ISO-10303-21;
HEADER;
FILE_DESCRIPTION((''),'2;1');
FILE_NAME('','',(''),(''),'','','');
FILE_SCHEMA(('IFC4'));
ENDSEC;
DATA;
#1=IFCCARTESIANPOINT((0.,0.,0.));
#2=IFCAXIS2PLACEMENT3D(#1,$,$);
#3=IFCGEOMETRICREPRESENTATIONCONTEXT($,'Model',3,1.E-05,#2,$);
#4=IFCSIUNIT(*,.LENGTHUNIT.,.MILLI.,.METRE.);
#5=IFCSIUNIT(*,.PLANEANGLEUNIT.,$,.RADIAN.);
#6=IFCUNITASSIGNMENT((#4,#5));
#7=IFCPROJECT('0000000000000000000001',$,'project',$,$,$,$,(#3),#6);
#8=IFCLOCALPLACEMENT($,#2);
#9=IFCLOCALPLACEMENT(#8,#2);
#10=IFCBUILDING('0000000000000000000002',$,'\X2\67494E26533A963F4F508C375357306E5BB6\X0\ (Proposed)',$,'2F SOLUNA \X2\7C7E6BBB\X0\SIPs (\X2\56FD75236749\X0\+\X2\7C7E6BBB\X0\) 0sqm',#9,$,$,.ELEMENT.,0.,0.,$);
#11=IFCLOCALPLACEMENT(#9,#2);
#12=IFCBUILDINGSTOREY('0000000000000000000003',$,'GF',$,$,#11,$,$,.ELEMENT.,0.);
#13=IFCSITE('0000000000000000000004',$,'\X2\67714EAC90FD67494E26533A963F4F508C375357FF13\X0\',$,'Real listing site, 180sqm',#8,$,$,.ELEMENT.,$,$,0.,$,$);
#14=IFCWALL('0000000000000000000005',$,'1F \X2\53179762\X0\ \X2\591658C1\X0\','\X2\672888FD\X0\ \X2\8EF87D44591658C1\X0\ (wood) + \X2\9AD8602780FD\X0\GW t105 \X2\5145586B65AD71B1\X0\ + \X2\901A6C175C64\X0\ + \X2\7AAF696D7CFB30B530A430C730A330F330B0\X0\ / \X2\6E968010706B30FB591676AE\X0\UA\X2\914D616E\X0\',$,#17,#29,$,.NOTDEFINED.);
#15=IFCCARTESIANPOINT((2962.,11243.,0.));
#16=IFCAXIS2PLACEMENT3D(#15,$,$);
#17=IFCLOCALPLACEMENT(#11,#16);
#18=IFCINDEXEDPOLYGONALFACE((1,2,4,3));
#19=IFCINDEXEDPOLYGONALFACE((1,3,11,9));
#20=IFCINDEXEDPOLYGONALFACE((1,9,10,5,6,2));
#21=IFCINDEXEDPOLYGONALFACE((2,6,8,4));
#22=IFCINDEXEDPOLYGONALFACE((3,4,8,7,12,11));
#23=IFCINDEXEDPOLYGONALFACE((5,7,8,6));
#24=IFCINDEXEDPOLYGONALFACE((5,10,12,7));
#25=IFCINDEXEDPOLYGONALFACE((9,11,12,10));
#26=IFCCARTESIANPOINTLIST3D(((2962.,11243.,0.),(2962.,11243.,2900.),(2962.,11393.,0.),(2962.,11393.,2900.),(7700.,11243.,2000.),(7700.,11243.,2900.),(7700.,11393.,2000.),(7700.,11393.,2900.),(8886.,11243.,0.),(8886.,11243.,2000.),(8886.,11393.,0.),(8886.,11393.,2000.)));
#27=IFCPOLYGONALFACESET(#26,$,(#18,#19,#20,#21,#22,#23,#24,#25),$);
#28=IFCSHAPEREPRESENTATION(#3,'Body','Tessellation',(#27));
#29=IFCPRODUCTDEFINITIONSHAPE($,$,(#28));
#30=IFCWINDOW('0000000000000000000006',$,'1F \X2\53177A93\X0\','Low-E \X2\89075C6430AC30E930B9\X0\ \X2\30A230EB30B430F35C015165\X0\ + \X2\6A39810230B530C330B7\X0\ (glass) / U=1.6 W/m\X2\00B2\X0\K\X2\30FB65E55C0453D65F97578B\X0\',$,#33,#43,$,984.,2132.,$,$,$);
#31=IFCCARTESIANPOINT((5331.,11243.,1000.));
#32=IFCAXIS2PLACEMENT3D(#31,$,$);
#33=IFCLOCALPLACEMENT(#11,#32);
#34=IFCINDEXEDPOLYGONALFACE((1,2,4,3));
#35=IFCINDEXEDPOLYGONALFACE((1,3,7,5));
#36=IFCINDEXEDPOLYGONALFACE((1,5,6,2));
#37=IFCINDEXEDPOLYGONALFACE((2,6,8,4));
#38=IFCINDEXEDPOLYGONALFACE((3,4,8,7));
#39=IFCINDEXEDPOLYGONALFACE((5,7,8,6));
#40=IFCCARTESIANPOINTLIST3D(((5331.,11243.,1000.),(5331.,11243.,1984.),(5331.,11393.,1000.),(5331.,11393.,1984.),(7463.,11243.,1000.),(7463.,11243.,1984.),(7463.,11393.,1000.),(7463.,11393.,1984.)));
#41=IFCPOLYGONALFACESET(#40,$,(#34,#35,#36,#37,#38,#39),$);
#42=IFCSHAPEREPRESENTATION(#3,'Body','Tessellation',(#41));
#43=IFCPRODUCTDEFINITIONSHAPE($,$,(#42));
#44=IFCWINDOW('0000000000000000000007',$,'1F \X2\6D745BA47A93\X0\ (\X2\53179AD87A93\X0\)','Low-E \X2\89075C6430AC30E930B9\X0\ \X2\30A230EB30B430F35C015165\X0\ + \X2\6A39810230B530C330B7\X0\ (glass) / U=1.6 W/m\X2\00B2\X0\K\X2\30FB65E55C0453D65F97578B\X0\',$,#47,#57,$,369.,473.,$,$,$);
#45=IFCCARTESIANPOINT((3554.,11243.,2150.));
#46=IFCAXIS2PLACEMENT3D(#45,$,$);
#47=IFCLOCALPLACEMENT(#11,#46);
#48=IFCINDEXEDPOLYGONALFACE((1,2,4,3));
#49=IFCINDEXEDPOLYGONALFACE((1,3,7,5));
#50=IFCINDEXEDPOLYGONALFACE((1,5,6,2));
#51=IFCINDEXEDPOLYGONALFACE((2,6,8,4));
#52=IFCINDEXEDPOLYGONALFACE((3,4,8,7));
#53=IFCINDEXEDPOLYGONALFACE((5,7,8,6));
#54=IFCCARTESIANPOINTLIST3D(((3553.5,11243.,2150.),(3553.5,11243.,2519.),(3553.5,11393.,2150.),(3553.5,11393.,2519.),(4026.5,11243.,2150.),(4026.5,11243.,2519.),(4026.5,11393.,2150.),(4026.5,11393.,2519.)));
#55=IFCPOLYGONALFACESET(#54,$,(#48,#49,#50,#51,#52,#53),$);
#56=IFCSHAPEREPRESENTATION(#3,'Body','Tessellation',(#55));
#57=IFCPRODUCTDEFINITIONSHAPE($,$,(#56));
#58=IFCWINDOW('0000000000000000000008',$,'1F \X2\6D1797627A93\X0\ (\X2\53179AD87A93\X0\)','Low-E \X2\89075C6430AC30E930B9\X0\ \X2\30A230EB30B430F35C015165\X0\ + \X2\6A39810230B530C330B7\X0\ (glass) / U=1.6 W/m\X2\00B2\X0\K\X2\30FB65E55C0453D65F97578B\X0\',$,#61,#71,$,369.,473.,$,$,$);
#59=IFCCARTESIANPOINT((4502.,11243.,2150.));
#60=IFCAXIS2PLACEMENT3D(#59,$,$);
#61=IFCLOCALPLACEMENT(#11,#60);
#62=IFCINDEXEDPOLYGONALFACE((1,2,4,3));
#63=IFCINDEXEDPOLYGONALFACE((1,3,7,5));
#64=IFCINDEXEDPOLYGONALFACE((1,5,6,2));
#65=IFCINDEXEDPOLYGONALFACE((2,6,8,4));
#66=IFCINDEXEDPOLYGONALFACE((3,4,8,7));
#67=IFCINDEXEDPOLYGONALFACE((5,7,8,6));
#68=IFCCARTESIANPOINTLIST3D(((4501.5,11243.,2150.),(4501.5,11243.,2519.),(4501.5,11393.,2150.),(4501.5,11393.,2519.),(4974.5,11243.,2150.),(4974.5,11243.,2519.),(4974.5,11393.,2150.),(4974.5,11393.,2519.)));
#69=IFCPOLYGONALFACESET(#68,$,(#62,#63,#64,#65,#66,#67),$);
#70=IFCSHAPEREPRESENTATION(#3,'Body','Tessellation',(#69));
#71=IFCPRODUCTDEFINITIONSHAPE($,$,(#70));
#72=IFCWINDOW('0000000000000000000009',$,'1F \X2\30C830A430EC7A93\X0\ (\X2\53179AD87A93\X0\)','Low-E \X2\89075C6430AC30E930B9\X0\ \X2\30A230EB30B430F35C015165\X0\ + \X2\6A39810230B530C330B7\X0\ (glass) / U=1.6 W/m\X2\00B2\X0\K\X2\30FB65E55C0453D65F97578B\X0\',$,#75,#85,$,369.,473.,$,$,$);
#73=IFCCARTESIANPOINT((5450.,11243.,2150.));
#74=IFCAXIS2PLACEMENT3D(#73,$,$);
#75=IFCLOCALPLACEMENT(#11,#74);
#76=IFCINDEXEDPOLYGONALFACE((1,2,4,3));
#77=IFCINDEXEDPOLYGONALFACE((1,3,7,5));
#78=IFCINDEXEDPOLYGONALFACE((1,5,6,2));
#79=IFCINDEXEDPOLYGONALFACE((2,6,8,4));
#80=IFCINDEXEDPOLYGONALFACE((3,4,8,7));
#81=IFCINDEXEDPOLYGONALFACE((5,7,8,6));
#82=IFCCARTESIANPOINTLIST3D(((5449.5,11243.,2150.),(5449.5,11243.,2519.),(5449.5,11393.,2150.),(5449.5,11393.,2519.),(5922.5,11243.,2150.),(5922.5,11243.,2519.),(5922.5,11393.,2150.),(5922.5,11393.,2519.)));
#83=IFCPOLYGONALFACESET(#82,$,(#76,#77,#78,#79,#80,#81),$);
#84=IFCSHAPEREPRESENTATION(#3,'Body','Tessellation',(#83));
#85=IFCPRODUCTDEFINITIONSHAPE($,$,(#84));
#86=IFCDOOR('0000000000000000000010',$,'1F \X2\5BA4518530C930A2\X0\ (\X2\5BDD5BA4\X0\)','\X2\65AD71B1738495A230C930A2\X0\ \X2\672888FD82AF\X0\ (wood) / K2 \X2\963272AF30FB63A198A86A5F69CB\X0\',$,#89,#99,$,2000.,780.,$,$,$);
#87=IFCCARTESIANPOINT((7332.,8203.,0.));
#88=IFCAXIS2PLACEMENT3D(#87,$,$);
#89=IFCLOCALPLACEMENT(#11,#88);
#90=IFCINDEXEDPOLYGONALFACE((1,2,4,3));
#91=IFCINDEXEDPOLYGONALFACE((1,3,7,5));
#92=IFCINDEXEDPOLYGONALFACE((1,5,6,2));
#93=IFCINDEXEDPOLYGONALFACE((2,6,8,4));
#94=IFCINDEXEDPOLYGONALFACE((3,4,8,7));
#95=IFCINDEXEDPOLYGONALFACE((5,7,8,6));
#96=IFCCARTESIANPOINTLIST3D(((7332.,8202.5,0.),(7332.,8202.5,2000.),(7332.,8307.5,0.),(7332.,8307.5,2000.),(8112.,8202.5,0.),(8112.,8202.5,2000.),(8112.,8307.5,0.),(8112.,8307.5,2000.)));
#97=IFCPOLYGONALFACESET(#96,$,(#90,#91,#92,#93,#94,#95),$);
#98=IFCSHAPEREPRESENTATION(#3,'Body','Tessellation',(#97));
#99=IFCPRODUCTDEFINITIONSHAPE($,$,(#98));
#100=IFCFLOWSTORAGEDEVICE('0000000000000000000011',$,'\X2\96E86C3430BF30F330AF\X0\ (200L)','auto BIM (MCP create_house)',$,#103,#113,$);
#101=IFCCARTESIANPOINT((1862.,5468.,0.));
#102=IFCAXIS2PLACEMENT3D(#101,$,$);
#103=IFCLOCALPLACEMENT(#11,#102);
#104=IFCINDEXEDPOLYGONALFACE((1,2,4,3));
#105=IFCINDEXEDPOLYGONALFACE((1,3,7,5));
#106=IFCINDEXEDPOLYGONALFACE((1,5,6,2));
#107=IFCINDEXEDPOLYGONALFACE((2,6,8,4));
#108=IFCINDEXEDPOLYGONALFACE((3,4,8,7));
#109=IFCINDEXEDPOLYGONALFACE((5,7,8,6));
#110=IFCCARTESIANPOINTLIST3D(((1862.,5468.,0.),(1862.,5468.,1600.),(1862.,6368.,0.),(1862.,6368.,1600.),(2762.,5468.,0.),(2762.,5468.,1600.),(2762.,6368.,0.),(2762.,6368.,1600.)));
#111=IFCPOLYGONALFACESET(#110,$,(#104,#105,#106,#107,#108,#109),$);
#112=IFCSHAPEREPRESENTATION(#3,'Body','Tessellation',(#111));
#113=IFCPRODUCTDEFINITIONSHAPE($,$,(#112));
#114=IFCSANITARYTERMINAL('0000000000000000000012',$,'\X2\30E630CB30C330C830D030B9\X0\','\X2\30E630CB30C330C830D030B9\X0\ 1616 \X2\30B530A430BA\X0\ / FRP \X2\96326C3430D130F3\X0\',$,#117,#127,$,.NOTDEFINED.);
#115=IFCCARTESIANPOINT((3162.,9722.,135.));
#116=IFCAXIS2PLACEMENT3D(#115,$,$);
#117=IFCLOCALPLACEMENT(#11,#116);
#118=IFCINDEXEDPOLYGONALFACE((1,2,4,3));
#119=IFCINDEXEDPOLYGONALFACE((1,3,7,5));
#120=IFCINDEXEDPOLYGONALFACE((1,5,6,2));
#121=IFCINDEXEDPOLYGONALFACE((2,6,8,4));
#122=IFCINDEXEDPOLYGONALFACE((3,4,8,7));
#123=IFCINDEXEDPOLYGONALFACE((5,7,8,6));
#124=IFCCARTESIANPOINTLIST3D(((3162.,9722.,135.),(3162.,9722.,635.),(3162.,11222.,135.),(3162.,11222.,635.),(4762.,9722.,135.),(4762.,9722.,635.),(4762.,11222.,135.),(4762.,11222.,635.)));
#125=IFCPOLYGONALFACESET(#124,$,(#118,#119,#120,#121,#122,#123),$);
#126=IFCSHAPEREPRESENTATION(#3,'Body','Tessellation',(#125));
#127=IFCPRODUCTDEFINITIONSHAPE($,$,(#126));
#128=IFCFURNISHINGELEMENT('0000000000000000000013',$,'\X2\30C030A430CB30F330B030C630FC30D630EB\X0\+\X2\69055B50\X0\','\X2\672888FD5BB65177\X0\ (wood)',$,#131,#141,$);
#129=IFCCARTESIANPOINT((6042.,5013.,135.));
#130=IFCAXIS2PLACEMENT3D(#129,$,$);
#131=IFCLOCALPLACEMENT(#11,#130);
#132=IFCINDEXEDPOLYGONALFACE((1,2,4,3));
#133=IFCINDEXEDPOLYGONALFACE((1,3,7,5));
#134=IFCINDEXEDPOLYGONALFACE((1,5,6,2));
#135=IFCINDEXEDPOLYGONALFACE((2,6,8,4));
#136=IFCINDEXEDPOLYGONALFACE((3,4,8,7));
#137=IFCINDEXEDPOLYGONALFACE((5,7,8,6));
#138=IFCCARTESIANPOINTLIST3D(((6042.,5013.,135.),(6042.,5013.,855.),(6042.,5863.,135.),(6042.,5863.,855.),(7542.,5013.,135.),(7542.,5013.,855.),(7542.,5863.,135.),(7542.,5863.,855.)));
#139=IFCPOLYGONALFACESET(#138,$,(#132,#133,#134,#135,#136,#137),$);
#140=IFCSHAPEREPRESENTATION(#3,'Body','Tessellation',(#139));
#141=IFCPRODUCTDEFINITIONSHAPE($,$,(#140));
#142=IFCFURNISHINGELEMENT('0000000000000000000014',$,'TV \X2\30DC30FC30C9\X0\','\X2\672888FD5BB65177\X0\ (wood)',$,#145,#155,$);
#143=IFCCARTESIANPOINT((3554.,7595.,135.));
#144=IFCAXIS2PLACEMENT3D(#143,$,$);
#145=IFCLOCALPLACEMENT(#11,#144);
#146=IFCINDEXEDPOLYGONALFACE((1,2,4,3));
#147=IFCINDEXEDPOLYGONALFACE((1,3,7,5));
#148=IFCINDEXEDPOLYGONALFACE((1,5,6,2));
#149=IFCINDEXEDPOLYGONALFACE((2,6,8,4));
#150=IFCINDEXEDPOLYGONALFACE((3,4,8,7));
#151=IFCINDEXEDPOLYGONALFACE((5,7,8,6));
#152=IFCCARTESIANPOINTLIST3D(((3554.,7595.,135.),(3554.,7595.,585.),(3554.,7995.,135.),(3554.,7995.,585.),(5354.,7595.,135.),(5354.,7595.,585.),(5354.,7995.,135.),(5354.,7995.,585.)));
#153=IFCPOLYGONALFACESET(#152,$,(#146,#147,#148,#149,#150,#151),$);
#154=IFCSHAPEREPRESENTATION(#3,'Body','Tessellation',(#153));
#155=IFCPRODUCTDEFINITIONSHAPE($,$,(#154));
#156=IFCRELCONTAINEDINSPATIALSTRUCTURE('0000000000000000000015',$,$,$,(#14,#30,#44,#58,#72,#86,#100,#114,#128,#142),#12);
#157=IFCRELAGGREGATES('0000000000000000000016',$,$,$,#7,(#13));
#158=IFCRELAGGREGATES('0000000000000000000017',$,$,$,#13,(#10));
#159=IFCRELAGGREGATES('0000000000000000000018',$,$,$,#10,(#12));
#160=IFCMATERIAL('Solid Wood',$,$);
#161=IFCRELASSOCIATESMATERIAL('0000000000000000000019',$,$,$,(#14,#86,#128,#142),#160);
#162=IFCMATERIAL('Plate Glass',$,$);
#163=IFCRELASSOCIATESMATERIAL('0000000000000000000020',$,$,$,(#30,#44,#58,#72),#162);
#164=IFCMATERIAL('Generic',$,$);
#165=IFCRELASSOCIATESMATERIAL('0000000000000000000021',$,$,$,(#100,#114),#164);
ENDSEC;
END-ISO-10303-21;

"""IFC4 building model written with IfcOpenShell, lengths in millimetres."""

from ifc_helpers import new_model, si_unit, frame, frame_2d, origin, place, context, project, spatial, rectangle, extrude, material, element, fill, save


model = new_model("IFC4")

# Units and contexts
model_context = context("Model", 3, precision=1e-05, world=origin())
ifc_project = project(units=[si_unit("LENGTHUNIT", "METRE", prefix="MILLI"), si_unit("PLANEANGLEUNIT", "RADIAN")], contexts=[model_context])

# Site, building, storey
site_placement = place(None, origin())
site = spatial("IfcSite", under=ifc_project, at=site_placement, Name="東京都杉並区阿佐谷南３", ObjectType="Real listing site, 180sqm", CompositionType="ELEMENT", RefElevation=0.0)
building_placement = place(site_placement, origin())
building = spatial("IfcBuilding", under=site, at=building_placement, Name="杉並区阿佐谷南の家 (Proposed)", ObjectType="2F SOLUNA 籾殻SIPs (国産杉+籾殻) 0sqm", CompositionType="ELEMENT", ElevationOfRefHeight=0.0, ElevationOfTerrain=0.0)
storey_placement = place(building_placement, origin())
storey = spatial("IfcBuildingStorey", under=building, at=storey_placement, Name="GF", CompositionType="ELEMENT", Elevation=0.0)

# Wall, openings, windows
ifc_material_1 = material(Name="Solid Wood")
wall_1_placement = place(storey_placement, frame((2962.0, 11243.0, 0.0)))
wall_1 = element("IfcWall", 1, at=wall_1_placement, inside=storey, material=ifc_material_1, Name="1F 北面 外壁", Description="木製 軸組外壁 (wood) + 高性能GW t105 充填断熱 + 通気層 + 窯業系サイディング / 準耐火・外皮UA配慮", PredefinedType="NOTDEFINED", context=model_context, shape_type="SweptSolid", body=[
    extrude(rectangle(XDim=5924.0, YDim=150.0, at=frame_2d((2962.0, 75.0))), frame((2962.0, 11243.0, 0.0)), (0.0, 0.0, 1.0), 2900.0),
])
opening_1_placement = place(storey_placement, frame((5331.0, 11243.0, 1000.0)))
opening_1 = element("IfcOpeningElement", 2, at=opening_1_placement, cuts=wall_1, PredefinedType="NOTDEFINED", context=model_context, shape_type="SweptSolid", body=[
    extrude(rectangle(XDim=2132.0, YDim=150.0, at=frame_2d((1066.0, 75.0))), frame((5331.0, 11243.0, 1000.0)), (0.0, 0.0, 1.0), 984.0),
])
opening_2_placement = place(storey_placement, frame((3554.0, 11243.0, 2150.0)))
opening_2 = element("IfcOpeningElement", 3, at=opening_2_placement, cuts=wall_1, PredefinedType="NOTDEFINED", context=model_context, shape_type="SweptSolid", body=[
    extrude(rectangle(XDim=473.0, YDim=150.0, at=frame_2d((236.0, 75.0))), frame((3554.0, 11243.0, 2150.0)), (0.0, 0.0, 1.0), 369.0),
])
opening_3_placement = place(storey_placement, frame((4502.0, 11243.0, 2150.0)))
opening_3 = element("IfcOpeningElement", 4, at=opening_3_placement, cuts=wall_1, PredefinedType="NOTDEFINED", context=model_context, shape_type="SweptSolid", body=[
    extrude(rectangle(XDim=473.0, YDim=150.0, at=frame_2d((236.0, 75.0))), frame((4502.0, 11243.0, 2150.0)), (0.0, 0.0, 1.0), 369.0),
])
opening_4_placement = place(storey_placement, frame((5450.0, 11243.0, 2150.0)))
opening_4 = element("IfcOpeningElement", 5, at=opening_4_placement, cuts=wall_1, PredefinedType="NOTDEFINED", context=model_context, shape_type="SweptSolid", body=[
    extrude(rectangle(XDim=473.0, YDim=150.0, at=frame_2d((236.0, 75.0))), frame((5450.0, 11243.0, 2150.0)), (0.0, 0.0, 1.0), 369.0),
])
ifc_material_2 = material(Name="Plate Glass")
window_1_placement = place(storey_placement, frame((5331.0, 11243.0, 1000.0)))
window_1 = element("IfcWindow", 6, at=window_1_placement, inside=storey, material=ifc_material_2, Name="1F 北窓", Description="Low-E 複層ガラス アルゴン封入 + 樹脂サッシ (glass) / U=1.6 W/m²K・日射取得型", OverallHeight=984.0, OverallWidth=2132.0, context=model_context, shape_type="SweptSolid", body=[
    extrude(rectangle(XDim=2132.0, YDim=150.0, at=frame_2d((1066.0, 75.0))), frame((5331.0, 11243.0, 1000.0)), (0.0, 0.0, 1.0), 984.0),
])
fill(opening_1, window_1)
window_2_placement = place(storey_placement, frame((3554.0, 11243.0, 2150.0)))
window_2 = element("IfcWindow", 7, at=window_2_placement, inside=storey, material=ifc_material_2, Name="1F 浴室窓 (北高窓)", Description="Low-E 複層ガラス アルゴン封入 + 樹脂サッシ (glass) / U=1.6 W/m²K・日射取得型", OverallHeight=369.0, OverallWidth=473.0, context=model_context, shape_type="SweptSolid", body=[
    extrude(rectangle(XDim=473.0, YDim=150.0, at=frame_2d((236.0, 75.0))), frame((3554.0, 11243.0, 2150.0)), (0.0, 0.0, 1.0), 369.0),
])
fill(opening_2, window_2)
window_3_placement = place(storey_placement, frame((4502.0, 11243.0, 2150.0)))
window_3 = element("IfcWindow", 8, at=window_3_placement, inside=storey, material=ifc_material_2, Name="1F 洗面窓 (北高窓)", Description="Low-E 複層ガラス アルゴン封入 + 樹脂サッシ (glass) / U=1.6 W/m²K・日射取得型", OverallHeight=369.0, OverallWidth=473.0, context=model_context, shape_type="SweptSolid", body=[
    extrude(rectangle(XDim=473.0, YDim=150.0, at=frame_2d((236.0, 75.0))), frame((4502.0, 11243.0, 2150.0)), (0.0, 0.0, 1.0), 369.0),
])
fill(opening_3, window_3)
window_4_placement = place(storey_placement, frame((5450.0, 11243.0, 2150.0)))
window_4 = element("IfcWindow", 9, at=window_4_placement, inside=storey, material=ifc_material_2, Name="1F トイレ窓 (北高窓)", Description="Low-E 複層ガラス アルゴン封入 + 樹脂サッシ (glass) / U=1.6 W/m²K・日射取得型", OverallHeight=369.0, OverallWidth=473.0, context=model_context, shape_type="SweptSolid", body=[
    extrude(rectangle(XDim=473.0, YDim=150.0, at=frame_2d((236.0, 75.0))), frame((5450.0, 11243.0, 2150.0)), (0.0, 0.0, 1.0), 369.0),
])
fill(opening_4, window_4)

# Door
door_1_placement = place(storey_placement, frame((7332.0, 8203.0, 0.0)))
element("IfcDoor", 10, at=door_1_placement, inside=storey, material=ifc_material_1, Name="1F 室内ドア (寝室)", Description="断熱玄関ドア 木製芯 (wood) / K2 防犯・採風機構", OverallHeight=2000.0, OverallWidth=780.0, context=model_context, shape_type="SweptSolid", body=[
    extrude(rectangle(XDim=780.0, YDim=105.0, at=frame_2d((390.0, 52.0))), frame((7332.0, 8203.0, 0.0)), (0.0, 0.0, 1.0), 2000.0),
])

# Flow storage device
ifc_material_3 = material(Name="Generic")
flow_storage_device_placement = place(storey_placement, frame((1862.0, 5468.0, 0.0)))
element("IfcFlowStorageDevice", 11, at=flow_storage_device_placement, inside=storey, material=ifc_material_3, Name="雨水タンク (200L)", Description="auto BIM (MCP create_house)", context=model_context, shape_type="SweptSolid", body=[
    extrude(rectangle(XDim=900.0, YDim=900.0, at=frame_2d((450.0, 450.0))), frame((1862.0, 5468.0, 0.0)), (0.0, 0.0, 1.0), 1600.0),
])

# Sanitary terminal
sanitary_terminal_placement = place(storey_placement, frame((3162.0, 9722.0, 135.0)))
element("IfcSanitaryTerminal", 12, at=sanitary_terminal_placement, inside=storey, material=ifc_material_3, Name="ユニットバス", Description="ユニットバス 1616 サイズ / FRP 防水パン", PredefinedType="NOTDEFINED", context=model_context, shape_type="SweptSolid", body=[
    extrude(rectangle(XDim=1600.0, YDim=1500.0, at=frame_2d((800.0, 750.0))), frame((3162.0, 9722.0, 135.0)), (0.0, 0.0, 1.0), 500.0),
])

# Furnishing elements
furnishing_1_placement = place(storey_placement, frame((6042.0, 5013.0, 135.0)))
element("IfcFurnishingElement", 13, at=furnishing_1_placement, inside=storey, material=ifc_material_1, Name="ダイニングテーブル+椅子", Description="木製家具 (wood)", context=model_context, shape_type="SweptSolid", body=[
    extrude(rectangle(XDim=1500.0, YDim=850.0, at=frame_2d((750.0, 425.0))), frame((6042.0, 5013.0, 135.0)), (0.0, 0.0, 1.0), 720.0),
])
furnishing_2_placement = place(storey_placement, frame((3554.0, 7595.0, 135.0)))
element("IfcFurnishingElement", 14, at=furnishing_2_placement, inside=storey, material=ifc_material_1, Name="TV ボード", Description="木製家具 (wood)", context=model_context, shape_type="SweptSolid", body=[
    extrude(rectangle(XDim=1800.0, YDim=400.0, at=frame_2d((900.0, 200.0))), frame((3554.0, 7595.0, 135.0)), (0.0, 0.0, 1.0), 450.0),
])

save(model, "model.ifc")
